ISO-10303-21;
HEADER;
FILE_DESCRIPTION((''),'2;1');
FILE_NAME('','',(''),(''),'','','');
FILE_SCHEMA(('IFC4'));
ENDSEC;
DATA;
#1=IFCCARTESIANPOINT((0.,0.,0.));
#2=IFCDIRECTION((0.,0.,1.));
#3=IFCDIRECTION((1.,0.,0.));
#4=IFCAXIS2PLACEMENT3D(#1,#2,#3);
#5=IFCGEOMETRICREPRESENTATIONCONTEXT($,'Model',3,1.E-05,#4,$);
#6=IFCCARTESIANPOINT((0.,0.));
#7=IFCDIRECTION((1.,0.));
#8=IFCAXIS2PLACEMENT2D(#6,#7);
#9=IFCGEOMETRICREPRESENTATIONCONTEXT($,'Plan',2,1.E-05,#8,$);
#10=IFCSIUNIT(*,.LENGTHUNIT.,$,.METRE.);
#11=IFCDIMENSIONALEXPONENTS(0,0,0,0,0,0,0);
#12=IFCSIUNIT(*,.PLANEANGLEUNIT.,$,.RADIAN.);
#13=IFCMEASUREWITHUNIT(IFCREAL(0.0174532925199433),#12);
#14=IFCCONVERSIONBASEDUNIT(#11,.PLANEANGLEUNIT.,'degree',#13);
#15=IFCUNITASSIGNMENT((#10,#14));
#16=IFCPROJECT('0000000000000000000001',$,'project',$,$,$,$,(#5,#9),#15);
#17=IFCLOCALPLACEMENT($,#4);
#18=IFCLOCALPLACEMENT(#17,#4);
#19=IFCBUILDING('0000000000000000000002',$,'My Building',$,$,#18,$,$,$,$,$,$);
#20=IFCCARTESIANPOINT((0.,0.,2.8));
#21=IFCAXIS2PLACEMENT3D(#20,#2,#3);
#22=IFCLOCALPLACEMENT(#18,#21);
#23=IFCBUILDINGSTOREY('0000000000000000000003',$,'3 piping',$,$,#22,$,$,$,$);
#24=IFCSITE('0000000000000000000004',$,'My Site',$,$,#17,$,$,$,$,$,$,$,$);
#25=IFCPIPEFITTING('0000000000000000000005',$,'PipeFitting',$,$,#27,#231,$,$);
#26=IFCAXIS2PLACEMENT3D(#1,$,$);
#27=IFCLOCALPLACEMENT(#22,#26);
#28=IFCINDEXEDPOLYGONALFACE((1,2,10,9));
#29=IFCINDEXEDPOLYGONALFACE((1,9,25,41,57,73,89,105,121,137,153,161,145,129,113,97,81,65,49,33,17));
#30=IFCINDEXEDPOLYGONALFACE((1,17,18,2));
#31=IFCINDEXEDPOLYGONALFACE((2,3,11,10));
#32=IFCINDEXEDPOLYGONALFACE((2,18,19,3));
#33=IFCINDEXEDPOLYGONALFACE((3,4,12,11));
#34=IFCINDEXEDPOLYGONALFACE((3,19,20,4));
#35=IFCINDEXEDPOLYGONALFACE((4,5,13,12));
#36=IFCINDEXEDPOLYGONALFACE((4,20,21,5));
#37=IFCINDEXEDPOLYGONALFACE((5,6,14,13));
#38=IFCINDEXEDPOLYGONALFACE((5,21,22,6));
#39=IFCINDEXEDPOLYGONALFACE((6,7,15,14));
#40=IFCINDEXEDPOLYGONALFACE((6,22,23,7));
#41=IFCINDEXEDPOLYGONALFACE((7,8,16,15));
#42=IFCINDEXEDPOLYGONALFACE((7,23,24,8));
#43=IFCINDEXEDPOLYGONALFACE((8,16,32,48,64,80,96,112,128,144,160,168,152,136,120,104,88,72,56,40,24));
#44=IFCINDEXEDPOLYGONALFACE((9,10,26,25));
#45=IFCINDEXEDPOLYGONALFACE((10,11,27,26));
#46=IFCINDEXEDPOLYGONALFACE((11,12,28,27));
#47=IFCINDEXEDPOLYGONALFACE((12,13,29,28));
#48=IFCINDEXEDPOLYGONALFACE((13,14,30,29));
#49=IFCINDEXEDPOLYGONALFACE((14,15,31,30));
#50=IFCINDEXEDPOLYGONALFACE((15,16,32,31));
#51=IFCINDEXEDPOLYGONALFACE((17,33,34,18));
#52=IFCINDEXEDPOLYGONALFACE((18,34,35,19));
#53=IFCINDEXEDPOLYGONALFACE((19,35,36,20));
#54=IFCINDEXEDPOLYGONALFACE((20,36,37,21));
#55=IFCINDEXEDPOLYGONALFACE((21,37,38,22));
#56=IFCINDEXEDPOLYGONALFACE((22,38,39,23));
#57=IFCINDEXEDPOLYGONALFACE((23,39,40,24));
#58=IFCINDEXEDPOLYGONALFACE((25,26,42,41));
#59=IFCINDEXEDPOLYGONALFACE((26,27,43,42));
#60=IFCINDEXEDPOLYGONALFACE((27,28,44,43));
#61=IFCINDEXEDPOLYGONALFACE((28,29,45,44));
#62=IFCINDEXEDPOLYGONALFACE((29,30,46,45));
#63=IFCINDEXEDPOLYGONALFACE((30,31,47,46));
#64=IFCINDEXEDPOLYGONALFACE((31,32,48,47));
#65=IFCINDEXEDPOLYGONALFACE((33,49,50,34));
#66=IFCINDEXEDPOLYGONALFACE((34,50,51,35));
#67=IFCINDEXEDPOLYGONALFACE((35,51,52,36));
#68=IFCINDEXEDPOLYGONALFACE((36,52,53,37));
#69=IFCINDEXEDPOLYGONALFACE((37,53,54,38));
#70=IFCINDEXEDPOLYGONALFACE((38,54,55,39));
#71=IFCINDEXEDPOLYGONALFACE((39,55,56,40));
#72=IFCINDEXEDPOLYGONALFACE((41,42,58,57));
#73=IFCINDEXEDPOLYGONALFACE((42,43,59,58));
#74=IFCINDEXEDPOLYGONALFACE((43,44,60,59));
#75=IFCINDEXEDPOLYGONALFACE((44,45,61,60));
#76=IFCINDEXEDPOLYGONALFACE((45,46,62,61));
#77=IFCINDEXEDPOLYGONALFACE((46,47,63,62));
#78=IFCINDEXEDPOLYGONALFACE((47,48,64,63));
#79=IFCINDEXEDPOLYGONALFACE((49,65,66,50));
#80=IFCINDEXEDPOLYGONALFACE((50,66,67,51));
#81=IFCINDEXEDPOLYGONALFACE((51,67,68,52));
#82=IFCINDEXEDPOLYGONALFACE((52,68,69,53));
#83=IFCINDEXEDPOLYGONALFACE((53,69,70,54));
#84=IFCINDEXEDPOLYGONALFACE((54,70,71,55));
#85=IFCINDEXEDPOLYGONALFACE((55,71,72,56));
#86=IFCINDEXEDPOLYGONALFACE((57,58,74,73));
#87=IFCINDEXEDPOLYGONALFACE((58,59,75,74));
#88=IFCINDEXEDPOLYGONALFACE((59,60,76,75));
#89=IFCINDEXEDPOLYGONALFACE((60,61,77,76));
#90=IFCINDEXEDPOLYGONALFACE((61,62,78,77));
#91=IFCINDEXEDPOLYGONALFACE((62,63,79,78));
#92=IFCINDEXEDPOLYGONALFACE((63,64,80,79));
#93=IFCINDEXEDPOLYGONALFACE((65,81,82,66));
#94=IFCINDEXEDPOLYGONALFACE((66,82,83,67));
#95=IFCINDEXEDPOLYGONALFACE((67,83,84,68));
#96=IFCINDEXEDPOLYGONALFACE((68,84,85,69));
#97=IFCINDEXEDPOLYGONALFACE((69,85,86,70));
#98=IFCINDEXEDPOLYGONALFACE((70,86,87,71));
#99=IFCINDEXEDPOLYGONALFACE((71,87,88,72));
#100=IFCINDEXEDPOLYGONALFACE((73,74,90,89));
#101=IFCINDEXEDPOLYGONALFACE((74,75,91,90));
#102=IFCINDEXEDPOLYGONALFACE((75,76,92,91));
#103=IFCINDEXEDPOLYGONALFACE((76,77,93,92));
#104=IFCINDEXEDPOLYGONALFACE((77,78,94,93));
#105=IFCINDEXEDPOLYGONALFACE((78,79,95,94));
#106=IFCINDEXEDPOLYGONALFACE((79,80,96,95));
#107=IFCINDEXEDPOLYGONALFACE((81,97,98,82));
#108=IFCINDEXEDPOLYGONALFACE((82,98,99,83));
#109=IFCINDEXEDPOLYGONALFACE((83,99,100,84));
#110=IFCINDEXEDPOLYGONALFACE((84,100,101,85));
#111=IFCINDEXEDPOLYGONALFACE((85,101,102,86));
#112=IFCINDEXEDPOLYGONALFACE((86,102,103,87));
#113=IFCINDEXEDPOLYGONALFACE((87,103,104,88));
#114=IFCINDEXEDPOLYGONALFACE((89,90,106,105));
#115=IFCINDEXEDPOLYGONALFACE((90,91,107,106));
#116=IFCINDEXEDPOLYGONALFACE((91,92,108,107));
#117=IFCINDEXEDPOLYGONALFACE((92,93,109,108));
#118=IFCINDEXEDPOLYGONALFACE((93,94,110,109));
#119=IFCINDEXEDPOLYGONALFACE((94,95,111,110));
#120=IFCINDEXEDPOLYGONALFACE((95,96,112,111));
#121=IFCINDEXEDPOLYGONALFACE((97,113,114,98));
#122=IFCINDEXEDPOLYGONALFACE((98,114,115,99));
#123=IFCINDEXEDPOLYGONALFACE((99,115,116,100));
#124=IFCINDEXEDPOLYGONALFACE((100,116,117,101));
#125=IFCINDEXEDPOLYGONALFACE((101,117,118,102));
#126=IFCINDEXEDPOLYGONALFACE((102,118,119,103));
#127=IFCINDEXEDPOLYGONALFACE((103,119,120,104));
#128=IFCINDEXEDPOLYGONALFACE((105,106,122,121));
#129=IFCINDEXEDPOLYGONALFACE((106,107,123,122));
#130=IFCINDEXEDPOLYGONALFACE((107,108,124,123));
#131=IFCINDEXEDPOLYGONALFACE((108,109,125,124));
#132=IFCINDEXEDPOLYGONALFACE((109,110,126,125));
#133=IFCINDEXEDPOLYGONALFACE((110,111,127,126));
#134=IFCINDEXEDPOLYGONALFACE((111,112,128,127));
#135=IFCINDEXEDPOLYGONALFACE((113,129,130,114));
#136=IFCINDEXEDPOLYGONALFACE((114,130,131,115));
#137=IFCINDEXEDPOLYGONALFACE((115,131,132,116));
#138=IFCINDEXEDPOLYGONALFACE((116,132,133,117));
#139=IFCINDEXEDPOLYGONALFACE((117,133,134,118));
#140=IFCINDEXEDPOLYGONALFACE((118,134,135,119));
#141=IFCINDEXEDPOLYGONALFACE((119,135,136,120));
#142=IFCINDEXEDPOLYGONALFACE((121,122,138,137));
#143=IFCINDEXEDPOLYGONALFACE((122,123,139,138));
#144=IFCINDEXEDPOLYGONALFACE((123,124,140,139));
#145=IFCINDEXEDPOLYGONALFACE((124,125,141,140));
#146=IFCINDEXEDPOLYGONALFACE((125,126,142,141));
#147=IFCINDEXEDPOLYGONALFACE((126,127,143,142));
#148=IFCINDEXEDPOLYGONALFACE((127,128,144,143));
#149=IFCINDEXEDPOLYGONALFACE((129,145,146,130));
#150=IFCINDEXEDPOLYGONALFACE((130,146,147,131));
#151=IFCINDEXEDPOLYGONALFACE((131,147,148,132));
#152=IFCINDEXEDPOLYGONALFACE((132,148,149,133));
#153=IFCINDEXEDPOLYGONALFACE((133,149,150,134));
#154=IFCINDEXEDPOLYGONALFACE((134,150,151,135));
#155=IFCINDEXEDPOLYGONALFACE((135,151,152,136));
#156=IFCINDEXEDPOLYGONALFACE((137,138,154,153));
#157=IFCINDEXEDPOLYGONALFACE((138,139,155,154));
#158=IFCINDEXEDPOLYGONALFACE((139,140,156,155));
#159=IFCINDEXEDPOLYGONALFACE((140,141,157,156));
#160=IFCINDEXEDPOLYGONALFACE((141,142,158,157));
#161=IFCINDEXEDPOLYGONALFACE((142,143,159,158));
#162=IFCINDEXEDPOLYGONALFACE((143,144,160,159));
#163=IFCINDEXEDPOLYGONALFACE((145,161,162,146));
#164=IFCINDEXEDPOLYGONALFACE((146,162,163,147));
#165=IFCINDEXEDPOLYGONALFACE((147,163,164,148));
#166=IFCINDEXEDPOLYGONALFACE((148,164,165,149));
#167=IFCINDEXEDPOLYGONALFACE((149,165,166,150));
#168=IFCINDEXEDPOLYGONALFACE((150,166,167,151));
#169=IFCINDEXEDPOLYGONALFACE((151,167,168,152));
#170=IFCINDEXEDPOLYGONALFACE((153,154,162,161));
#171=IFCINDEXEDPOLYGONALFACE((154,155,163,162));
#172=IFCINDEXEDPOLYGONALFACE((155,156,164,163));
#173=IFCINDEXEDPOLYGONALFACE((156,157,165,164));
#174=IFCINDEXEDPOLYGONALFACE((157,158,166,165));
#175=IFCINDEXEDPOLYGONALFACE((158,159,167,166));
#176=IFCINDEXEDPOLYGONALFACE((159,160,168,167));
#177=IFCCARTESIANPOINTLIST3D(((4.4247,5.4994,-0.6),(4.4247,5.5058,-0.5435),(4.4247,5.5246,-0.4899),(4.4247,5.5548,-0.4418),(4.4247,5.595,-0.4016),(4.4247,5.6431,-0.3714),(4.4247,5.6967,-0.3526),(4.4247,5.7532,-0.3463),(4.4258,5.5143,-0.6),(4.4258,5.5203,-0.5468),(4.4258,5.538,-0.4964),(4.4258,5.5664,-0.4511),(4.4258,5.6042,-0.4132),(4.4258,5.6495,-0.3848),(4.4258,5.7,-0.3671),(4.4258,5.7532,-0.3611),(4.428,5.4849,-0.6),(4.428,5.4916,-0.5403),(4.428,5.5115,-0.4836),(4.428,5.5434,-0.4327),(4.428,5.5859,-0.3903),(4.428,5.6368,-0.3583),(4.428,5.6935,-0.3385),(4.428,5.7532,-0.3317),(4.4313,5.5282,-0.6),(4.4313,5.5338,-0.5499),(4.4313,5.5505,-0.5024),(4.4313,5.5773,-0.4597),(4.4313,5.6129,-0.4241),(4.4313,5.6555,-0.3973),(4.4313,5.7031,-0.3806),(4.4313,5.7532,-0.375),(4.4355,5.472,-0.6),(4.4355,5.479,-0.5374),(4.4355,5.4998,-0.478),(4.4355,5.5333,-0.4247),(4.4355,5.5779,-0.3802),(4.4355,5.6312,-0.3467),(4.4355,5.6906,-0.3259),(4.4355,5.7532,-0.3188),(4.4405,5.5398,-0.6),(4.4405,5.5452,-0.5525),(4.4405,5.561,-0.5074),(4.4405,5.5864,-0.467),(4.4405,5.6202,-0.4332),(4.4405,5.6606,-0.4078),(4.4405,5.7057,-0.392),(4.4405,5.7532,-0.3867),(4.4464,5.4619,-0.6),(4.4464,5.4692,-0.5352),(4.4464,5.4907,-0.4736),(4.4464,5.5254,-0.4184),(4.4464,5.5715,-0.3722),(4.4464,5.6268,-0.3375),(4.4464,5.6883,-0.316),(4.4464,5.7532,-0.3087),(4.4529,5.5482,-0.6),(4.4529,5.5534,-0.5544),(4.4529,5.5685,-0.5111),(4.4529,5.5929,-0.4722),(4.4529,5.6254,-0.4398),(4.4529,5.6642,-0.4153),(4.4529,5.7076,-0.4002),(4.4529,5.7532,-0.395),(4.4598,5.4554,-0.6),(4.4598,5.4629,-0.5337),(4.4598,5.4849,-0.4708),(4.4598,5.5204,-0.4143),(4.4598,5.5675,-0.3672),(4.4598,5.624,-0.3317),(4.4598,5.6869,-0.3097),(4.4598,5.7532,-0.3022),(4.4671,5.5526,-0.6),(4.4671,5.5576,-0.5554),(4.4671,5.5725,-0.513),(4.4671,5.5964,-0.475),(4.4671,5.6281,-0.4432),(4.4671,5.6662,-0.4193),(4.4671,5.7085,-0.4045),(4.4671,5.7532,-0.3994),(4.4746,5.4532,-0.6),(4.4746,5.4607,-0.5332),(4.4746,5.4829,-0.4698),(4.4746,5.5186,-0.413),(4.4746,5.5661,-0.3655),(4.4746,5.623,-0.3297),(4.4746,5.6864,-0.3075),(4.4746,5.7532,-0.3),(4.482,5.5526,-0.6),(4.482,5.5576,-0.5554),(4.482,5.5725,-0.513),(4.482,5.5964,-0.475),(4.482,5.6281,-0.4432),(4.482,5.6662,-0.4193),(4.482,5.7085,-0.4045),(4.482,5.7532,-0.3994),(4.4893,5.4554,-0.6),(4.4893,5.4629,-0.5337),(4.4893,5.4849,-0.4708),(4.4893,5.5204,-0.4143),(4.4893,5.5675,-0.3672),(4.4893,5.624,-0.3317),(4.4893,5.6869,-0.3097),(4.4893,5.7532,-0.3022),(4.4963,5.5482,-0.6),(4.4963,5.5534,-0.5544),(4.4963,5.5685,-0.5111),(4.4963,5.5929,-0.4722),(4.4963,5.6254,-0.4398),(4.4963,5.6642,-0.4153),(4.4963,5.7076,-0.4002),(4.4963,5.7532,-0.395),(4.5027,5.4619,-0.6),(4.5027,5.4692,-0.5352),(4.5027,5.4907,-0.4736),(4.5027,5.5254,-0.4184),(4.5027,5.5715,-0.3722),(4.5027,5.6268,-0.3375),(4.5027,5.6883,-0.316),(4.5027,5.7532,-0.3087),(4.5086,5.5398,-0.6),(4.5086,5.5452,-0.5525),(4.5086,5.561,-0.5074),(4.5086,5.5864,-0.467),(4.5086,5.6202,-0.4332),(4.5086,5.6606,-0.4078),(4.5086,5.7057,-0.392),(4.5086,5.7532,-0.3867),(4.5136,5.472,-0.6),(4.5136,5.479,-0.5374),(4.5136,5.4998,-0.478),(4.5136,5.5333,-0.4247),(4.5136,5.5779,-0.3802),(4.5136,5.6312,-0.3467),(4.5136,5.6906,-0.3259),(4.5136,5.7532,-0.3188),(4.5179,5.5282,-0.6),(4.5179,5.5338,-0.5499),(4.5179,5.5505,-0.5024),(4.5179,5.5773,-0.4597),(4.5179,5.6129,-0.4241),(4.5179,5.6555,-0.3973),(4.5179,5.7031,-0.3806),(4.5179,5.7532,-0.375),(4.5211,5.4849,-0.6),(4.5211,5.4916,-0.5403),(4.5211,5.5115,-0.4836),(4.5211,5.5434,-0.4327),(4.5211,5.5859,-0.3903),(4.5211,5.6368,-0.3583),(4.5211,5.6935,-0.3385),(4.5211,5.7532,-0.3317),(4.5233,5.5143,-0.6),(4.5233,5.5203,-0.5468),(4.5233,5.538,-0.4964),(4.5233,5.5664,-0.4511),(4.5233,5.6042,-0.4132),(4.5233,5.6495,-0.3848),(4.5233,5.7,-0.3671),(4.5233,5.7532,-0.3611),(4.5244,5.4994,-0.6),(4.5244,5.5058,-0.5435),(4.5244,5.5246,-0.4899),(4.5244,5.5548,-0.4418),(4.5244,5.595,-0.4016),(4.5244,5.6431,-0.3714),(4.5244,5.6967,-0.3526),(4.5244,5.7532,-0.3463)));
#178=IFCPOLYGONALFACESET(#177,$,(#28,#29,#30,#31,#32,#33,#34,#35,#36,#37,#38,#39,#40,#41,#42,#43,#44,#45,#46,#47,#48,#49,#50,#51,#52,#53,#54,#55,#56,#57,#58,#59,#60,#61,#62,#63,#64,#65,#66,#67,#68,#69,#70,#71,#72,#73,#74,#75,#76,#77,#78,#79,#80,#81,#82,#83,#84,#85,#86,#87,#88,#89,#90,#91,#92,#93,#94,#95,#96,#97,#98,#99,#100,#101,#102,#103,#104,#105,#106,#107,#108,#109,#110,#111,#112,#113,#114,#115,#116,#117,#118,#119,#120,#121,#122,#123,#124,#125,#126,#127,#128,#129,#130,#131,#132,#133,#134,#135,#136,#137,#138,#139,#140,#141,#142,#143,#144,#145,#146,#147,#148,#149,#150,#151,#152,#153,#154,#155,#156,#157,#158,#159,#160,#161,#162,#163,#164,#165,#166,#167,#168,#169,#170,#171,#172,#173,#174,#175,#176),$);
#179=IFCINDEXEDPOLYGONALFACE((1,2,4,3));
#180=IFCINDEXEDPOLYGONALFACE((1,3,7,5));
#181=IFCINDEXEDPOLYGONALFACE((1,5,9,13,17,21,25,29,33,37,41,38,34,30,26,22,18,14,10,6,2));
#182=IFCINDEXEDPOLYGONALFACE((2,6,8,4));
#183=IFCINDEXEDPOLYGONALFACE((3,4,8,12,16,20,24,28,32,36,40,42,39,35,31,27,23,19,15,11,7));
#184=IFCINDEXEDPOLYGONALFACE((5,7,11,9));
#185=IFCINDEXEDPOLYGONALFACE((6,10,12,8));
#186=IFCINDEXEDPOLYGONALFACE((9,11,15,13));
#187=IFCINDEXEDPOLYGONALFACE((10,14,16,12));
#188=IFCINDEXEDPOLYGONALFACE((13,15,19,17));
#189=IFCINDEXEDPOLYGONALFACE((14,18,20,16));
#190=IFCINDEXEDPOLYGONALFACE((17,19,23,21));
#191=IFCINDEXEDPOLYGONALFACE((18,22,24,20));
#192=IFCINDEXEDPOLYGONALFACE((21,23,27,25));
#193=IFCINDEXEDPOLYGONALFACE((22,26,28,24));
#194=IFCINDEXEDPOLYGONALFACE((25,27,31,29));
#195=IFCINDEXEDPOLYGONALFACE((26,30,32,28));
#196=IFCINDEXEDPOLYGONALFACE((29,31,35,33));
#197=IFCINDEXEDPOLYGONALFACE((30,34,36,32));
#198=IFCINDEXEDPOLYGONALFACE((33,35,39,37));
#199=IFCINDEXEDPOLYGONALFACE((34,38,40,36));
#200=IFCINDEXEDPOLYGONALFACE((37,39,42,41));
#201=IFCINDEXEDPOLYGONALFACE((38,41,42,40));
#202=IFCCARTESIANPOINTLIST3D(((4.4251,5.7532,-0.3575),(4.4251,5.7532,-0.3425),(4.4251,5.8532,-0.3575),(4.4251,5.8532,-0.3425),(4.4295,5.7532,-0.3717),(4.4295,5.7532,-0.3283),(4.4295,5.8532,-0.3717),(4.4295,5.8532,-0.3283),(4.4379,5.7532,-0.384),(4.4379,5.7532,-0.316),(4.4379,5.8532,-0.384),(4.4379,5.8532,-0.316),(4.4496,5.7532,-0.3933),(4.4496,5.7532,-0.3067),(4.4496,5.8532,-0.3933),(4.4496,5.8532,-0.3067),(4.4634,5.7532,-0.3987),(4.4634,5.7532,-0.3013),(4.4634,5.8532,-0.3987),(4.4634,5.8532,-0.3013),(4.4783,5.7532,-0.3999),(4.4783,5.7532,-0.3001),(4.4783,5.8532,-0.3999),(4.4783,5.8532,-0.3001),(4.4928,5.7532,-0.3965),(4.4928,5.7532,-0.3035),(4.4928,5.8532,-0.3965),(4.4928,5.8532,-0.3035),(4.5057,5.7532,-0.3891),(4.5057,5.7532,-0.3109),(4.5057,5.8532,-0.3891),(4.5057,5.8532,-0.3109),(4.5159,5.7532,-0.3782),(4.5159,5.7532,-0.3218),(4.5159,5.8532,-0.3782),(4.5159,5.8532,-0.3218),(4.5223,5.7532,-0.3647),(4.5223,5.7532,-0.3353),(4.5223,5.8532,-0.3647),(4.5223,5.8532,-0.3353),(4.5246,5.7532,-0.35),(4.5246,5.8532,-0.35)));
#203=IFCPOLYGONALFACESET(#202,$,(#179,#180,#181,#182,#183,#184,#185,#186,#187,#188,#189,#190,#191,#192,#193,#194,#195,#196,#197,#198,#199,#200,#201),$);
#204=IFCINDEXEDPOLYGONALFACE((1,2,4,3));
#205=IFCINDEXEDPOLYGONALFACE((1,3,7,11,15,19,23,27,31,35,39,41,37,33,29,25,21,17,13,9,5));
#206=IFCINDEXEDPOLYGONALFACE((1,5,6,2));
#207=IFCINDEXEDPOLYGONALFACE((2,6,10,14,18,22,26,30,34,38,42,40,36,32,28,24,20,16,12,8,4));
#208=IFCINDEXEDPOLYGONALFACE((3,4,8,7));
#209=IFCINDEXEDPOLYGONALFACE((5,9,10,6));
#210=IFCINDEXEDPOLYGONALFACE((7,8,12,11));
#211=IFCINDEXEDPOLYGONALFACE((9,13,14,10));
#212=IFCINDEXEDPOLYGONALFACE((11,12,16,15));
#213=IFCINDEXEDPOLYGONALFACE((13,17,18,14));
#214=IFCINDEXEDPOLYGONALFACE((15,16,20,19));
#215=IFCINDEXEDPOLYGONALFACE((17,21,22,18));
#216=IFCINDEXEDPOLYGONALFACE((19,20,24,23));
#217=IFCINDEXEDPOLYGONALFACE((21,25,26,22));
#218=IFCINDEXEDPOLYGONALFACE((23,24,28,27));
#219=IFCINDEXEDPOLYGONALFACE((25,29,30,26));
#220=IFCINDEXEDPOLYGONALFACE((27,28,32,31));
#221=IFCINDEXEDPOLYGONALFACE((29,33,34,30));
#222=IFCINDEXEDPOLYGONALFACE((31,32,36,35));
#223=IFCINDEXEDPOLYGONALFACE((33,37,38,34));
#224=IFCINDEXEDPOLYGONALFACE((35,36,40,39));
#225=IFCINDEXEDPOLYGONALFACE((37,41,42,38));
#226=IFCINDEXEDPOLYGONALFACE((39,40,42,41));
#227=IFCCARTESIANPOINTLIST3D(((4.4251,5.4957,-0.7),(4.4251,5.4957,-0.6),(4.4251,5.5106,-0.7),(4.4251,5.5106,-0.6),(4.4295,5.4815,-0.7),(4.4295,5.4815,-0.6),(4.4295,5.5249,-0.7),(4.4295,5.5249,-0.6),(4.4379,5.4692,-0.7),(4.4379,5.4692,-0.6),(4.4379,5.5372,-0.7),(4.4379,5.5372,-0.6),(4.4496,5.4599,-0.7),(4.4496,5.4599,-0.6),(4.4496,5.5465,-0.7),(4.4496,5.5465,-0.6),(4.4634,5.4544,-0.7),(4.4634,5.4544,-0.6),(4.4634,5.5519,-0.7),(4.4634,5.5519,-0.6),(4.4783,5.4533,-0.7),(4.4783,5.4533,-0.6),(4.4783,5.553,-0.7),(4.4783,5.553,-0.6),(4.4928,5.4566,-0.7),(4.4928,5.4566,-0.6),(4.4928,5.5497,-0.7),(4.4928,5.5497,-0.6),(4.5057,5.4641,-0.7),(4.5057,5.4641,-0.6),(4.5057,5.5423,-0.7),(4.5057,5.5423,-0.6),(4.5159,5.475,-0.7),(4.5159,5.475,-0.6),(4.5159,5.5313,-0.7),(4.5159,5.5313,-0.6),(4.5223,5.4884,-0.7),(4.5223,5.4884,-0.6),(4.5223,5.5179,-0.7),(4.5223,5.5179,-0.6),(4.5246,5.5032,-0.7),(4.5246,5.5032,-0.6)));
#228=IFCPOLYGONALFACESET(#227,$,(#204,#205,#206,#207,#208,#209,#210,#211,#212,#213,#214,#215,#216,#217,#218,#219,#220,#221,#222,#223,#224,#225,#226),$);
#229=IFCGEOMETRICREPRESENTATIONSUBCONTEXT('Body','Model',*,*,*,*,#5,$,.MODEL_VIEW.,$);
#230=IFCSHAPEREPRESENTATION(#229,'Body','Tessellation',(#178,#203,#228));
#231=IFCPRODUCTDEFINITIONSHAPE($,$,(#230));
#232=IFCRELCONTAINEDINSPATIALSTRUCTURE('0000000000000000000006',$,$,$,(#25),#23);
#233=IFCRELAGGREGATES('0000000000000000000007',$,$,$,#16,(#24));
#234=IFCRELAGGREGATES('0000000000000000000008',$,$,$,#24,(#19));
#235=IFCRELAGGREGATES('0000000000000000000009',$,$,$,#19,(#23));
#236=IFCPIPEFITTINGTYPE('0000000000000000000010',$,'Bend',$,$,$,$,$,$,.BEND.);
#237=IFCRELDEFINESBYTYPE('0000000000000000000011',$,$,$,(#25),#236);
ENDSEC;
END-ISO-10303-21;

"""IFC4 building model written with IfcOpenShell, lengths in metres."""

from ifc_helpers import new_model, entity, si_unit, converted_unit, frame, origin_with_axes, origin_2d_with_axis, place, context, subcontext, project, spatial, circle, extrude, source, transform, mapped, type_object, type_shapes, element, save


model = new_model("IFC4")

# Units and contexts
model_context = context("Model", 3, precision=1e-05, world=origin_with_axes())
plan_context = context("Plan", 2, precision=1e-05, world=origin_2d_with_axis())
body_context = subcontext(model_context, "Body", "Model", "MODEL_VIEW")
ifc_project = project(units=[si_unit("LENGTHUNIT", "METRE"), converted_unit("PLANEANGLEUNIT", "degree", entity("IfcReal", 0.0174532925199433), si_unit("PLANEANGLEUNIT", "RADIAN"), dimensions=[0, 0, 0, 0, 0, 0, 0])], contexts=[model_context, plan_context])

# Site, building, storey
site_placement = place(None, origin_with_axes())
site = spatial("IfcSite", under=ifc_project, at=site_placement, Name="My Site")
building_placement = place(site_placement, origin_with_axes())
building = spatial("IfcBuilding", under=site, at=building_placement, Name="My Building")
storey_placement = place(building_placement, frame((0.0, 0.0, 2.8), z_axis=(0.0, 0.0, 1.0), x_axis=(1.0, 0.0, 0.0)))
storey = spatial("IfcBuildingStorey", under=building, at=storey_placement, Name="3 piping")

# Pipe fitting
pipe_fitting_type_1 = type_object("IfcPipeFittingType", Name="Bend", PredefinedType="BEND")
shared_shape = source(origin_with_axes(), body_context, "Body", "SolidModel", [
    entity("IfcSweptDiskSolid", entity("IfcIndexedPolyCurve", entity("IfcCartesianPointList3D", [[0.0, 0.0, 0.1], [0.0, -0.0732, 0.2768], [0.0, -0.25, 0.35]]), [entity("IfcArcIndex", [1, 2, 3])]), 0.05),
    extrude(circle(Radius=0.05), origin_with_axes(), (0.0, 0.0, 1.0), 0.1),
    extrude(circle(Radius=0.05), frame((0.0, -0.25, 0.35), z_axis=(0.0, -1.0, 0.0), x_axis=(1.0, 0.0, 0.0)), (0.0, 0.0, 1.0), 0.1),
])
type_shapes(pipe_fitting_type_1, [shared_shape])
for number, where, z_axis, x_axis, name in (
    (1, (4.4746, 5.8532, -0.35), (0.0, -1.0, 0.0), (1.0, 0.0, 0.0), "PipeFitting"),
):
    element("IfcPipeFitting", number, at=place(storey_placement, frame(where, z_axis=z_axis, x_axis=x_axis)), inside=storey, type_object=pipe_fitting_type_1, Name=name, context=body_context, shape_type="MappedRepresentation", body=[
        mapped(shared_shape, transform((0.0, 0.0, 0.0), x_axis=(1.0, 0.0, 0.0), y_axis=(0.0, 1.0, 0.0), z_axis=(0.0, 0.0, 1.0), scale=1.0)),
    ])

save(model, "model.ifc")
